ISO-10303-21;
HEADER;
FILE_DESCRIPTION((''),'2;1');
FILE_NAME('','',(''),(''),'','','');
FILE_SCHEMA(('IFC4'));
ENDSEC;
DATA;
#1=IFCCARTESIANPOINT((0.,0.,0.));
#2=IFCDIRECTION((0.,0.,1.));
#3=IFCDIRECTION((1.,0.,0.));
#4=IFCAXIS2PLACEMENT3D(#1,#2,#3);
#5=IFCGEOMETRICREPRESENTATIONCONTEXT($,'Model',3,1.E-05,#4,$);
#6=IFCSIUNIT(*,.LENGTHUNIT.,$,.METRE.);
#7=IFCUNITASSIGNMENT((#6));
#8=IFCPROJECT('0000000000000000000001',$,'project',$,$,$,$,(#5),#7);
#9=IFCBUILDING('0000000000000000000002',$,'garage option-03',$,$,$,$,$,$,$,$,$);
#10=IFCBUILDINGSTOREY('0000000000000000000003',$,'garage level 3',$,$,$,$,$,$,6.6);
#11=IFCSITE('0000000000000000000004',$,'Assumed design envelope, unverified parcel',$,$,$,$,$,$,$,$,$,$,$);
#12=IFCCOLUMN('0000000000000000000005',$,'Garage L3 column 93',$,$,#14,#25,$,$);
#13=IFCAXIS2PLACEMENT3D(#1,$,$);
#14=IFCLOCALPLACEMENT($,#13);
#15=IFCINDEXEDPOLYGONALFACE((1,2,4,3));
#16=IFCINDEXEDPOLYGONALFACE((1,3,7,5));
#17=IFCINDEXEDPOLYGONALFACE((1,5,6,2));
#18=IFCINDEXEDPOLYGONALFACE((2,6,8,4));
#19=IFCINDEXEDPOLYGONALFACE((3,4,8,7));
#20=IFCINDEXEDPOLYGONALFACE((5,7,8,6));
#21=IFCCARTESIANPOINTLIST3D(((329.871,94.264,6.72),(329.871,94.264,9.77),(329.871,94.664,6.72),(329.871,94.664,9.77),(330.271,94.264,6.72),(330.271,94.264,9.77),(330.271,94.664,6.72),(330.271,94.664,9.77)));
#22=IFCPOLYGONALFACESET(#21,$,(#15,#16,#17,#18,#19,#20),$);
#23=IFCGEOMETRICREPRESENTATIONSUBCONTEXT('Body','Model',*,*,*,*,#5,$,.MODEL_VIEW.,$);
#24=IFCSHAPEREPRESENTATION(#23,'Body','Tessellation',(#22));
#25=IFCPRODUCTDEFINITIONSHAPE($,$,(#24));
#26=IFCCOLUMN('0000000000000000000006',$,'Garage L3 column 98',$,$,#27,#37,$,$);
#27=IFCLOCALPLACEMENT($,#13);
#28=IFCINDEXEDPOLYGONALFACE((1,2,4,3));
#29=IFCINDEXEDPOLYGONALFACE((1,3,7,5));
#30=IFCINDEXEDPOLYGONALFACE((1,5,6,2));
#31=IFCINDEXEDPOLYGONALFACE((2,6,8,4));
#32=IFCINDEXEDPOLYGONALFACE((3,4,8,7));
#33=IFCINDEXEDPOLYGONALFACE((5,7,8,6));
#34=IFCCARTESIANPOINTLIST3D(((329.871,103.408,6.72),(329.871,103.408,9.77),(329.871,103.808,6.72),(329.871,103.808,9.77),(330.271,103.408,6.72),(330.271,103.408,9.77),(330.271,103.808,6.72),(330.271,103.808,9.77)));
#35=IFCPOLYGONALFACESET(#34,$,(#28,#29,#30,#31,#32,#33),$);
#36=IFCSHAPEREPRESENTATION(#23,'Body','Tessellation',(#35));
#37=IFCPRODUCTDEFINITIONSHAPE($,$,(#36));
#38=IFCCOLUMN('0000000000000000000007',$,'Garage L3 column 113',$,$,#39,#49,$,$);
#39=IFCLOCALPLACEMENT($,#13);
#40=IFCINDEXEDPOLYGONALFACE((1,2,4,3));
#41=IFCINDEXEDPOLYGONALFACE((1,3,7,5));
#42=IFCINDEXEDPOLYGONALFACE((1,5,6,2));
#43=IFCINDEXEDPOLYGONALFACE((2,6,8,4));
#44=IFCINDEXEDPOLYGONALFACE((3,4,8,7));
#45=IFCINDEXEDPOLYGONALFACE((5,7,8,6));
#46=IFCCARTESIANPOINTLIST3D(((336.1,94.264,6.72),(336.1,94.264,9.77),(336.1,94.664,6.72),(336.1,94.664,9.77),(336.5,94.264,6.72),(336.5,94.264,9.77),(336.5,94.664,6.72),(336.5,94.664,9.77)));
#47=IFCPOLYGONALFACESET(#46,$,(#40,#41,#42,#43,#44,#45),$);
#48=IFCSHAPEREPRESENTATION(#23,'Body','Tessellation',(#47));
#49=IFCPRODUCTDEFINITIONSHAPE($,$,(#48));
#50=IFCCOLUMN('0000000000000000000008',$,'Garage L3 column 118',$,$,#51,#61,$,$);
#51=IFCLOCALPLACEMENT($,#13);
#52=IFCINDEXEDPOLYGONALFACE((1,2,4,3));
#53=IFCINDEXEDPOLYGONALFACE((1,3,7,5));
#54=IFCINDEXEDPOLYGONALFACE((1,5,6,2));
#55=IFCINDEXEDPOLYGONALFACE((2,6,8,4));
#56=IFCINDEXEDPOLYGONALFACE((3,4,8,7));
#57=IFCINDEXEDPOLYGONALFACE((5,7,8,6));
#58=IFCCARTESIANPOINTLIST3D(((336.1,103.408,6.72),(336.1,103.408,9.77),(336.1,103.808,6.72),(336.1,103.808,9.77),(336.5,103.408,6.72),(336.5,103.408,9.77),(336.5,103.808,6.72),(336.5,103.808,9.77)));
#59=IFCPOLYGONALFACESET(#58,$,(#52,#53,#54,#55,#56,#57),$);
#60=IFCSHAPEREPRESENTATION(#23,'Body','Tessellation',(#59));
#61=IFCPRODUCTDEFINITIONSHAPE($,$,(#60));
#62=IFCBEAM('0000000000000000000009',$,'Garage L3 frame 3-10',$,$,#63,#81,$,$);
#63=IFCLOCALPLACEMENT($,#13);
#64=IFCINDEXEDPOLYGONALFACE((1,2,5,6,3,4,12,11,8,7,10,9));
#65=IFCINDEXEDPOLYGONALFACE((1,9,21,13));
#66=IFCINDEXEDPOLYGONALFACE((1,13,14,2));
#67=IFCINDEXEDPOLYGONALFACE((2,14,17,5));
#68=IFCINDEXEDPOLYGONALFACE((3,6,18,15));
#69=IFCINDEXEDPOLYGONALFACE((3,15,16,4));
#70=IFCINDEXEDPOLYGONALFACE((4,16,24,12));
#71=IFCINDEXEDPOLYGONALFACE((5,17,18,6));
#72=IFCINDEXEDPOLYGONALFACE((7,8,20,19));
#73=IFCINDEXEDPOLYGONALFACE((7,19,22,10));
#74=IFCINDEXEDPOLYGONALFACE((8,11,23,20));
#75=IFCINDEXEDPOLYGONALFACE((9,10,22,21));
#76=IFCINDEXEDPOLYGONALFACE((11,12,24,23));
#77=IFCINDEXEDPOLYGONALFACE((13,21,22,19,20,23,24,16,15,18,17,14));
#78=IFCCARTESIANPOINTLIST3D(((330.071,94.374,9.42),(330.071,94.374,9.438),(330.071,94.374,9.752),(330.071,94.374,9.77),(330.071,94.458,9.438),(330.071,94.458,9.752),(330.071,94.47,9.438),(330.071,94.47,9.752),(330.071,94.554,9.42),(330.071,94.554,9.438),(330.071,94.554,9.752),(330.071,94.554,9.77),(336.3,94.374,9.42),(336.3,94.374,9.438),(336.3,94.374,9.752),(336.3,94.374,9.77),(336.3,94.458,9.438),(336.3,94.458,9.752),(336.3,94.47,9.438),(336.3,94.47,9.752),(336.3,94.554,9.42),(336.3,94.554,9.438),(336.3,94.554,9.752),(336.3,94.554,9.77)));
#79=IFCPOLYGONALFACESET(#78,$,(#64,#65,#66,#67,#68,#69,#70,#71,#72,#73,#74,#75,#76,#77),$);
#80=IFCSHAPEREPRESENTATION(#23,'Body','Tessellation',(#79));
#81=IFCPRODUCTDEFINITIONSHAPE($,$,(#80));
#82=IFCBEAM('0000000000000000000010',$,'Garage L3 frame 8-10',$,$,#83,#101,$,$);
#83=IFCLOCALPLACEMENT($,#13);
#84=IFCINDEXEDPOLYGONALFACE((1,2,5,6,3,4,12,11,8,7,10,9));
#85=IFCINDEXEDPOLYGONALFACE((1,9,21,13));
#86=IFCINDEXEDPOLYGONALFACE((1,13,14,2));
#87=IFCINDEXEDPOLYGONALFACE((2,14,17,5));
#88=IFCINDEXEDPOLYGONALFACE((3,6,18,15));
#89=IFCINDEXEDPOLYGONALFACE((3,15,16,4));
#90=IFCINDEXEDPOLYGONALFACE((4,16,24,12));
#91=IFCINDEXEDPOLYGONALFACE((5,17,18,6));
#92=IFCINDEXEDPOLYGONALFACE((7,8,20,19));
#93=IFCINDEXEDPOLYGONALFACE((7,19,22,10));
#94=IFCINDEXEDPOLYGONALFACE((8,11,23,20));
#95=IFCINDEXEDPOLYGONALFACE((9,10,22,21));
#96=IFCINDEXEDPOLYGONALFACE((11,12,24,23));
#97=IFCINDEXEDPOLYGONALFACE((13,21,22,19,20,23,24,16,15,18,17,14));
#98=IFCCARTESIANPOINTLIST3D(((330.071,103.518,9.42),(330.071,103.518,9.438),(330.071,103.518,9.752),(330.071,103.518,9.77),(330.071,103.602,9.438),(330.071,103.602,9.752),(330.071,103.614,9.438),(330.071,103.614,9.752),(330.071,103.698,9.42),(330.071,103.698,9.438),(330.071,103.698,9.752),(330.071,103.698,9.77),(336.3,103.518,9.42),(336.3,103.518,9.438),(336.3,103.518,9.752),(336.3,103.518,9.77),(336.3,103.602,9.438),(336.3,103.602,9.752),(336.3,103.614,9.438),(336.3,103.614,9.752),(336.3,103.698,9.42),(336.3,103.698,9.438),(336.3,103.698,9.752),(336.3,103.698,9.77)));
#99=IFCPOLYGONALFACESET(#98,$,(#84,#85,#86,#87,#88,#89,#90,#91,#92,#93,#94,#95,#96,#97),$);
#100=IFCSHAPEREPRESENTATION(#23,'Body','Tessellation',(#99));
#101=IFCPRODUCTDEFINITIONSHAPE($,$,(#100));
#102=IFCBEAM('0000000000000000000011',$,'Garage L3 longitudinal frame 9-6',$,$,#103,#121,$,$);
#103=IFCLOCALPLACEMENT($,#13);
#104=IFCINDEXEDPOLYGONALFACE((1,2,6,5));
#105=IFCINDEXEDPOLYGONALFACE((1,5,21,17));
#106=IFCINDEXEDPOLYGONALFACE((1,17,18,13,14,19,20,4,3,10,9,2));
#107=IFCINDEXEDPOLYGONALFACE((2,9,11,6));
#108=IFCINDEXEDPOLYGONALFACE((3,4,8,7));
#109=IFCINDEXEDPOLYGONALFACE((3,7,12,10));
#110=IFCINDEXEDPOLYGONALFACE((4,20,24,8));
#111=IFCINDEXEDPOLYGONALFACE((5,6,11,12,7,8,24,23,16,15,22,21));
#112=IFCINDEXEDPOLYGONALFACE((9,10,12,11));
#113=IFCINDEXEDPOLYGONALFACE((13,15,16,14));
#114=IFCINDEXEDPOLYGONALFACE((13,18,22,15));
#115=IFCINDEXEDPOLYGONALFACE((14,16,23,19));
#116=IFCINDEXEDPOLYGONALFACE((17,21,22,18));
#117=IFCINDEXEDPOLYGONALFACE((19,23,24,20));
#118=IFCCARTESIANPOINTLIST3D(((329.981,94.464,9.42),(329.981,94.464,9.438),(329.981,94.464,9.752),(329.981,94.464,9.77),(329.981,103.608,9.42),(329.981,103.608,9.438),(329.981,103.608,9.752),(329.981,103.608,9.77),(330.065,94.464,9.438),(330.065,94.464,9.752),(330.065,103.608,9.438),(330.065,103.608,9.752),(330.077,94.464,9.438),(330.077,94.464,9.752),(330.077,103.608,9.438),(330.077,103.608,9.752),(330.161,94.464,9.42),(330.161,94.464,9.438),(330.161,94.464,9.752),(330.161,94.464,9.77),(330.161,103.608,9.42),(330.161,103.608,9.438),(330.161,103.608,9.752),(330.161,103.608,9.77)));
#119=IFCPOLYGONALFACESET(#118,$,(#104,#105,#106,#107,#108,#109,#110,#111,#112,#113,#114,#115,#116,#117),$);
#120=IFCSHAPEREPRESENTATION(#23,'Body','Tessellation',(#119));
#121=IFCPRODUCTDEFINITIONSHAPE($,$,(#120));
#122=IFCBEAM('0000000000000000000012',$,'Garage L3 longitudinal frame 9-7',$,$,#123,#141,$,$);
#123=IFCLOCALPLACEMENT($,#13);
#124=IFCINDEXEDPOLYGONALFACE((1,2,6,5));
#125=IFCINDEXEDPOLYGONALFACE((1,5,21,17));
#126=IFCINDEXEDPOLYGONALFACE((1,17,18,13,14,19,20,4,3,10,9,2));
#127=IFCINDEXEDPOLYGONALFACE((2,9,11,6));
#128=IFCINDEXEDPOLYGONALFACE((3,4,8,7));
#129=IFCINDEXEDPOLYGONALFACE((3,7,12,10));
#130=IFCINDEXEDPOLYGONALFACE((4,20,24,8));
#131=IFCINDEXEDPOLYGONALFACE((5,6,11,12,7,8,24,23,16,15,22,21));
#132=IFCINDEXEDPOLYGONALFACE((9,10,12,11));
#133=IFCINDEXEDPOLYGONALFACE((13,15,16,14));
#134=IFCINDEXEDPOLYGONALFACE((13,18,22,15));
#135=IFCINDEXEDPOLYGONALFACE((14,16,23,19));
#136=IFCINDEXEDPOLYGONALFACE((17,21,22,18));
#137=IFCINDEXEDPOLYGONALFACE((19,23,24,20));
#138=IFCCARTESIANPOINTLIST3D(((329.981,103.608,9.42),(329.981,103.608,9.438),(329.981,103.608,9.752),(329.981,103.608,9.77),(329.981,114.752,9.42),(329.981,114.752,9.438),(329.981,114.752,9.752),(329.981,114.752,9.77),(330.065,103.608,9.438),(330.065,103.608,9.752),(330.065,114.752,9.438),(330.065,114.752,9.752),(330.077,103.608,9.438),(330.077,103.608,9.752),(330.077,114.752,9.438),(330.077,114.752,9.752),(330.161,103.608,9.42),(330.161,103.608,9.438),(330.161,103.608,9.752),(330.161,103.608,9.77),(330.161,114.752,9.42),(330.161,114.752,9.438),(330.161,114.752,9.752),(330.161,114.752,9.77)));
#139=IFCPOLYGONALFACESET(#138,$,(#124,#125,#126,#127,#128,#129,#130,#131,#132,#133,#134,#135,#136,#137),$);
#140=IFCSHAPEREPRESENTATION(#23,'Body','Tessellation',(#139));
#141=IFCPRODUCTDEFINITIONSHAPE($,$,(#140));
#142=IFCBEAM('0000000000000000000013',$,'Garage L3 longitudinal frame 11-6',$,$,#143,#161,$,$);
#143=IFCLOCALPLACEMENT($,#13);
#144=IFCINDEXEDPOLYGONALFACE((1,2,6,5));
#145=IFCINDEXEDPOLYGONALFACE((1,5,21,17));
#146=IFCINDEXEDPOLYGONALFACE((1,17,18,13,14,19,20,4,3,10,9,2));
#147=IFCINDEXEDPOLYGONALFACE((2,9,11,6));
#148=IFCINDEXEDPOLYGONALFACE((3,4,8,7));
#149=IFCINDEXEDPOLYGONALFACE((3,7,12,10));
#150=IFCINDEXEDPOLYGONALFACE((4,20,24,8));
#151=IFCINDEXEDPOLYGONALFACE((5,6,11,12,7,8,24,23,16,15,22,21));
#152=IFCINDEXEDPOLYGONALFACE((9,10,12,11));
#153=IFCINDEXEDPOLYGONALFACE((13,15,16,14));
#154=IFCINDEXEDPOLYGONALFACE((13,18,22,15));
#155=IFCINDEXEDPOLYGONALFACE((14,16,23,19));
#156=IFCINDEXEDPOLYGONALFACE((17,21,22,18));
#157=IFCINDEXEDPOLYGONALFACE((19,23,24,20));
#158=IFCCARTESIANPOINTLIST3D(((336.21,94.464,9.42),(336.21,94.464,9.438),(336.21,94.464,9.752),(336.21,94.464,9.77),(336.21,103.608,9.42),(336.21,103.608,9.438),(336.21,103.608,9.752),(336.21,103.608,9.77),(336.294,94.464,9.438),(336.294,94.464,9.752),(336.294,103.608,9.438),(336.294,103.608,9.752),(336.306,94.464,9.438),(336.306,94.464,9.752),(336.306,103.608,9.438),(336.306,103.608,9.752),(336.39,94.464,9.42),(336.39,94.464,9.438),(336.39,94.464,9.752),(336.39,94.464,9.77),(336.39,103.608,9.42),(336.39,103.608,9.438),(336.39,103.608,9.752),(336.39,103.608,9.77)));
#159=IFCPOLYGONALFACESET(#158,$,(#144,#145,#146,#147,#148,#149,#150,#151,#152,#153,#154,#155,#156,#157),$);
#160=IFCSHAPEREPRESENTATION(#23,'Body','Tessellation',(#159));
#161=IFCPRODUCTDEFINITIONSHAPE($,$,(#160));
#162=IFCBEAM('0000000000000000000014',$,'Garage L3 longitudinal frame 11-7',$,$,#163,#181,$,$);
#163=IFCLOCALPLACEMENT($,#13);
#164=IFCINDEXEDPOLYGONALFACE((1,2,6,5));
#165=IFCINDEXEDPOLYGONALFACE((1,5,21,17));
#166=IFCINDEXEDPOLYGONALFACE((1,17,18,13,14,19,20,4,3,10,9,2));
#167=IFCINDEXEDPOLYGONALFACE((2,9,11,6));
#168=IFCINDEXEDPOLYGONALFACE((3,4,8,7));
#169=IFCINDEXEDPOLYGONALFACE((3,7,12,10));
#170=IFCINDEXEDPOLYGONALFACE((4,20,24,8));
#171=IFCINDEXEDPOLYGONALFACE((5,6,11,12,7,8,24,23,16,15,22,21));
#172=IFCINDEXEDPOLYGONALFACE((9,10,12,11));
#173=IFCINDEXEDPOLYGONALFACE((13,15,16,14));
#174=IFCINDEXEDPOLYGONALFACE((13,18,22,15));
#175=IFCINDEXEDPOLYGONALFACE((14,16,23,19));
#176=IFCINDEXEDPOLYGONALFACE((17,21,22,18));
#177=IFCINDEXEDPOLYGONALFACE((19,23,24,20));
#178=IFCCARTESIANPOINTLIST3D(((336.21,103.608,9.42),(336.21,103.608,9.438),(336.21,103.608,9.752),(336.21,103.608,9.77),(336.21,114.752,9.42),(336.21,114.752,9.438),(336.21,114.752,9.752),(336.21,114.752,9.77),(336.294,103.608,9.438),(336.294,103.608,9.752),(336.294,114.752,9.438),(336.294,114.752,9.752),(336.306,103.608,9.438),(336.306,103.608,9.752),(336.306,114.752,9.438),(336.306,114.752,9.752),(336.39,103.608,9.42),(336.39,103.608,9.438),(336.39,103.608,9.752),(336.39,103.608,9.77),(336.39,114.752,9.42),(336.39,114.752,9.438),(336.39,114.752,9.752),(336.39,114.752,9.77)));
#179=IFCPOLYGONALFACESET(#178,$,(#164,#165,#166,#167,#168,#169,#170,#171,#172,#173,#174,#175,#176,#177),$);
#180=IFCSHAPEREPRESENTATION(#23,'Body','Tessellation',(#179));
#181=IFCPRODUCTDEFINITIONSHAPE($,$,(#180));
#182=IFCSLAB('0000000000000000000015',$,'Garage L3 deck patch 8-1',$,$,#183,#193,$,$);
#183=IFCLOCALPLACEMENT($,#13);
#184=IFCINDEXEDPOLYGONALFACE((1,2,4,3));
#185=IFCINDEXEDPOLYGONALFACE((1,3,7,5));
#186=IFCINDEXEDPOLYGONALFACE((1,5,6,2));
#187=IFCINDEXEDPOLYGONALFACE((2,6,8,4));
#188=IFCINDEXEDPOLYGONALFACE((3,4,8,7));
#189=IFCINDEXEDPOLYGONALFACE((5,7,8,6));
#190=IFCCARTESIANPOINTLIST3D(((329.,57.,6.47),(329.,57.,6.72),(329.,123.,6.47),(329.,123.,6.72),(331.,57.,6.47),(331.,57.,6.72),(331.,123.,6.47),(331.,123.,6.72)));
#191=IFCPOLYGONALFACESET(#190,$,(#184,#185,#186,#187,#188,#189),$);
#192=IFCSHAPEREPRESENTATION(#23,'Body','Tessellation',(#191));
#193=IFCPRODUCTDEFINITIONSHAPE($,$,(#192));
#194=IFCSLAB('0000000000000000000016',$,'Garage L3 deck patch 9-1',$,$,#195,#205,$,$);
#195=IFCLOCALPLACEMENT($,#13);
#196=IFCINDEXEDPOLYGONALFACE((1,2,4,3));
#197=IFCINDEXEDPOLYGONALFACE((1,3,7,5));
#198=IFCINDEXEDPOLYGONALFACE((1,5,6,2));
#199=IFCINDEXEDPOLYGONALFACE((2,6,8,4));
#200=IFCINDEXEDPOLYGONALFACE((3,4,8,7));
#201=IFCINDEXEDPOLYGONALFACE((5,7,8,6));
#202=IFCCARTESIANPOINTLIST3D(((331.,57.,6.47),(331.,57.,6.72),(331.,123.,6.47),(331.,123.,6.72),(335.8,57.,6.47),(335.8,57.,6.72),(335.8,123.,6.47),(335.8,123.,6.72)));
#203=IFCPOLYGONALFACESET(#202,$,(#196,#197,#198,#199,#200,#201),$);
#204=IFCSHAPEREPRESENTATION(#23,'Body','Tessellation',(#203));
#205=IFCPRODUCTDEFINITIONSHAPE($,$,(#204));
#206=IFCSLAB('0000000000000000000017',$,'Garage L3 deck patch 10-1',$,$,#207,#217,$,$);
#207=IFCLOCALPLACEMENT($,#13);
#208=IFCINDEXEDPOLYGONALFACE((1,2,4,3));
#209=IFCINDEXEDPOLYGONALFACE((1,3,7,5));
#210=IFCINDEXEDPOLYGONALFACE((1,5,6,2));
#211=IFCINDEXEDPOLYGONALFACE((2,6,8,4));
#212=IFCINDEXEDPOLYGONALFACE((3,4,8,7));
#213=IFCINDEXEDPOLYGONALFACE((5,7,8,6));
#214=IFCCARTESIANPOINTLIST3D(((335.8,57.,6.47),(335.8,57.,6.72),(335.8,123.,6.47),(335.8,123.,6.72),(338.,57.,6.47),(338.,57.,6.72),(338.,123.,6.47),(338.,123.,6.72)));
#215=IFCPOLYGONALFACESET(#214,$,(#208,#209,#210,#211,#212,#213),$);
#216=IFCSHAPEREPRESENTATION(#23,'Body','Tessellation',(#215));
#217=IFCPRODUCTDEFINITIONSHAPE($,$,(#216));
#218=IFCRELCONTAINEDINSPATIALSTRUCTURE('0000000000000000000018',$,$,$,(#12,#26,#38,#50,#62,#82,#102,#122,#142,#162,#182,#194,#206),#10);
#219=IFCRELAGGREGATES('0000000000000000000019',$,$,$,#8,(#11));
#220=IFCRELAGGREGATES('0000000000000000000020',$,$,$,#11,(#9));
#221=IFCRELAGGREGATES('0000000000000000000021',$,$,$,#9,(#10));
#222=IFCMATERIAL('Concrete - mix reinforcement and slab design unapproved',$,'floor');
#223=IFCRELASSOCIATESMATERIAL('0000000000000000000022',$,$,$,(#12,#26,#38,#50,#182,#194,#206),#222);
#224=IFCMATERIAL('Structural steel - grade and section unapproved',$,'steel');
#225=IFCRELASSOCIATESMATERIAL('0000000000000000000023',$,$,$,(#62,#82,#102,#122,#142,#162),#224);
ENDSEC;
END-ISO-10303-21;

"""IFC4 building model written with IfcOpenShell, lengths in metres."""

from ifc_helpers import new_model, si_unit, frame, origin_with_axes, place, context, subcontext, project, spatial, rectangle, i_section, extrude, material, element, save


model = new_model("IFC4")

# Units and contexts
model_context = context("Model", 3, precision=1e-05, world=origin_with_axes())
body_context = subcontext(model_context, "Body", "Model", "MODEL_VIEW")
ifc_project = project(units=[si_unit("LENGTHUNIT", "METRE")], contexts=[model_context])

# Site, building, storey
site = spatial("IfcSite", under=ifc_project, Name="Assumed design envelope, unverified parcel")
building = spatial("IfcBuilding", under=site, Name="garage option-03")
storey = spatial("IfcBuildingStorey", under=building, Name="garage level 3", Elevation=6.6)

# Columns
ifc_material_1 = material(Name="Concrete - mix reinforcement and slab design unapproved", Category="floor")
for number, where, z_axis, x_axis, name in (
    (1, (330.071, 94.464, 6.72), (0.0, 0.0, 1.0), (1.0, 0.0, 0.0), "Garage L3 column 93"),
    (2, (330.071, 103.608, 6.72), (0.0, 0.0, 1.0), (1.0, 0.0, 0.0), "Garage L3 column 98"),
    (3, (336.3, 94.464, 6.72), (0.0, 0.0, 1.0), (1.0, 0.0, 0.0), "Garage L3 column 113"),
    (4, (336.3, 103.608, 6.72), (0.0, 0.0, 1.0), (1.0, 0.0, 0.0), "Garage L3 column 118"),
):
    element("IfcColumn", number, at=place(None, frame(where, z_axis=z_axis, x_axis=x_axis)), inside=storey, material=ifc_material_1, Name=name, context=body_context, shape_type="SweptSolid", body=[
        extrude(rectangle(XDim=0.4, YDim=0.4), origin_with_axes(), (0.0, 0.0, 1.0), 3.05),
    ])

# Beams
ifc_material_2 = material(Name="Structural steel - grade and section unapproved", Category="steel")
for number, where, z_axis, x_axis, name in (
    (5, (330.071, 94.464, 9.595), (1.0, 0.0, 0.0), (0.0, 1.0, 0.0), "Garage L3 frame 3-10"),
    (6, (330.071, 103.608, 9.595), (1.0, 0.0, 0.0), (0.0, 1.0, 0.0), "Garage L3 frame 8-10"),
):
    element("IfcBeam", number, at=place(None, frame(where, z_axis=z_axis, x_axis=x_axis)), inside=storey, material=ifc_material_2, Name=name, context=body_context, shape_type="SweptSolid", body=[
        extrude(i_section(OverallWidth=0.18, OverallDepth=0.35, WebThickness=0.012, FlangeThickness=0.018, FilletRadius=0.0), origin_with_axes(), (0.0, 0.0, 1.0), 6.229),
    ])
beam_1_placement = place(None, frame((330.071, 94.464, 9.595), z_axis=(0.0, 1.0, 0.0), x_axis=(-1.0, 0.0, 0.0)))
element("IfcBeam", 7, at=beam_1_placement, inside=storey, material=ifc_material_2, Name="Garage L3 longitudinal frame 9-6", context=body_context, shape_type="SweptSolid", body=[
    extrude(i_section(OverallWidth=0.18, OverallDepth=0.35, WebThickness=0.012, FlangeThickness=0.018, FilletRadius=0.0), origin_with_axes(), (0.0, 0.0, 1.0), 9.144),
])
beam_2_placement = place(None, frame((330.071, 103.608, 9.595), z_axis=(0.0, 1.0, 0.0), x_axis=(-1.0, 0.0, 0.0)))
element("IfcBeam", 8, at=beam_2_placement, inside=storey, material=ifc_material_2, Name="Garage L3 longitudinal frame 9-7", context=body_context, shape_type="SweptSolid", body=[
    extrude(i_section(OverallWidth=0.18, OverallDepth=0.35, WebThickness=0.012, FlangeThickness=0.018, FilletRadius=0.0), origin_with_axes(), (0.0, 0.0, 1.0), 11.144),
])
beam_3_placement = place(None, frame((336.3, 94.464, 9.595), z_axis=(0.0, 1.0, 0.0), x_axis=(-1.0, 0.0, 0.0)))
element("IfcBeam", 9, at=beam_3_placement, inside=storey, material=ifc_material_2, Name="Garage L3 longitudinal frame 11-6", context=body_context, shape_type="SweptSolid", body=[
    extrude(i_section(OverallWidth=0.18, OverallDepth=0.35, WebThickness=0.012, FlangeThickness=0.018, FilletRadius=0.0), origin_with_axes(), (0.0, 0.0, 1.0), 9.144),
])
beam_4_placement = place(None, frame((336.3, 103.608, 9.595), z_axis=(0.0, 1.0, 0.0), x_axis=(-1.0, 0.0, 0.0)))
element("IfcBeam", 10, at=beam_4_placement, inside=storey, material=ifc_material_2, Name="Garage L3 longitudinal frame 11-7", context=body_context, shape_type="SweptSolid", body=[
    extrude(i_section(OverallWidth=0.18, OverallDepth=0.35, WebThickness=0.012, FlangeThickness=0.018, FilletRadius=0.0), origin_with_axes(), (0.0, 0.0, 1.0), 11.144),
])

# Slabs
slab_1_placement = place(None, frame((330.0, 90.0, 6.47), z_axis=(0.0, 0.0, 1.0), x_axis=(1.0, 0.0, 0.0)))
element("IfcSlab", 11, at=slab_1_placement, inside=storey, material=ifc_material_1, Name="Garage L3 deck patch 8-1", context=body_context, shape_type="SweptSolid", body=[
    extrude(rectangle(XDim=2.0, YDim=66.0), origin_with_axes(), (0.0, 0.0, 1.0), 0.25),
])
slab_2_placement = place(None, frame((333.4, 90.0, 6.47), z_axis=(0.0, 0.0, 1.0), x_axis=(1.0, 0.0, 0.0)))
element("IfcSlab", 12, at=slab_2_placement, inside=storey, material=ifc_material_1, Name="Garage L3 deck patch 9-1", context=body_context, shape_type="SweptSolid", body=[
    extrude(rectangle(XDim=4.8, YDim=66.0), origin_with_axes(), (0.0, 0.0, 1.0), 0.25),
])
slab_3_placement = place(None, frame((336.9, 90.0, 6.47), z_axis=(0.0, 0.0, 1.0), x_axis=(1.0, 0.0, 0.0)))
element("IfcSlab", 13, at=slab_3_placement, inside=storey, material=ifc_material_1, Name="Garage L3 deck patch 10-1", context=body_context, shape_type="SweptSolid", body=[
    extrude(rectangle(XDim=2.2, YDim=66.0), origin_with_axes(), (0.0, 0.0, 1.0), 0.25),
])

save(model, "model.ifc")
